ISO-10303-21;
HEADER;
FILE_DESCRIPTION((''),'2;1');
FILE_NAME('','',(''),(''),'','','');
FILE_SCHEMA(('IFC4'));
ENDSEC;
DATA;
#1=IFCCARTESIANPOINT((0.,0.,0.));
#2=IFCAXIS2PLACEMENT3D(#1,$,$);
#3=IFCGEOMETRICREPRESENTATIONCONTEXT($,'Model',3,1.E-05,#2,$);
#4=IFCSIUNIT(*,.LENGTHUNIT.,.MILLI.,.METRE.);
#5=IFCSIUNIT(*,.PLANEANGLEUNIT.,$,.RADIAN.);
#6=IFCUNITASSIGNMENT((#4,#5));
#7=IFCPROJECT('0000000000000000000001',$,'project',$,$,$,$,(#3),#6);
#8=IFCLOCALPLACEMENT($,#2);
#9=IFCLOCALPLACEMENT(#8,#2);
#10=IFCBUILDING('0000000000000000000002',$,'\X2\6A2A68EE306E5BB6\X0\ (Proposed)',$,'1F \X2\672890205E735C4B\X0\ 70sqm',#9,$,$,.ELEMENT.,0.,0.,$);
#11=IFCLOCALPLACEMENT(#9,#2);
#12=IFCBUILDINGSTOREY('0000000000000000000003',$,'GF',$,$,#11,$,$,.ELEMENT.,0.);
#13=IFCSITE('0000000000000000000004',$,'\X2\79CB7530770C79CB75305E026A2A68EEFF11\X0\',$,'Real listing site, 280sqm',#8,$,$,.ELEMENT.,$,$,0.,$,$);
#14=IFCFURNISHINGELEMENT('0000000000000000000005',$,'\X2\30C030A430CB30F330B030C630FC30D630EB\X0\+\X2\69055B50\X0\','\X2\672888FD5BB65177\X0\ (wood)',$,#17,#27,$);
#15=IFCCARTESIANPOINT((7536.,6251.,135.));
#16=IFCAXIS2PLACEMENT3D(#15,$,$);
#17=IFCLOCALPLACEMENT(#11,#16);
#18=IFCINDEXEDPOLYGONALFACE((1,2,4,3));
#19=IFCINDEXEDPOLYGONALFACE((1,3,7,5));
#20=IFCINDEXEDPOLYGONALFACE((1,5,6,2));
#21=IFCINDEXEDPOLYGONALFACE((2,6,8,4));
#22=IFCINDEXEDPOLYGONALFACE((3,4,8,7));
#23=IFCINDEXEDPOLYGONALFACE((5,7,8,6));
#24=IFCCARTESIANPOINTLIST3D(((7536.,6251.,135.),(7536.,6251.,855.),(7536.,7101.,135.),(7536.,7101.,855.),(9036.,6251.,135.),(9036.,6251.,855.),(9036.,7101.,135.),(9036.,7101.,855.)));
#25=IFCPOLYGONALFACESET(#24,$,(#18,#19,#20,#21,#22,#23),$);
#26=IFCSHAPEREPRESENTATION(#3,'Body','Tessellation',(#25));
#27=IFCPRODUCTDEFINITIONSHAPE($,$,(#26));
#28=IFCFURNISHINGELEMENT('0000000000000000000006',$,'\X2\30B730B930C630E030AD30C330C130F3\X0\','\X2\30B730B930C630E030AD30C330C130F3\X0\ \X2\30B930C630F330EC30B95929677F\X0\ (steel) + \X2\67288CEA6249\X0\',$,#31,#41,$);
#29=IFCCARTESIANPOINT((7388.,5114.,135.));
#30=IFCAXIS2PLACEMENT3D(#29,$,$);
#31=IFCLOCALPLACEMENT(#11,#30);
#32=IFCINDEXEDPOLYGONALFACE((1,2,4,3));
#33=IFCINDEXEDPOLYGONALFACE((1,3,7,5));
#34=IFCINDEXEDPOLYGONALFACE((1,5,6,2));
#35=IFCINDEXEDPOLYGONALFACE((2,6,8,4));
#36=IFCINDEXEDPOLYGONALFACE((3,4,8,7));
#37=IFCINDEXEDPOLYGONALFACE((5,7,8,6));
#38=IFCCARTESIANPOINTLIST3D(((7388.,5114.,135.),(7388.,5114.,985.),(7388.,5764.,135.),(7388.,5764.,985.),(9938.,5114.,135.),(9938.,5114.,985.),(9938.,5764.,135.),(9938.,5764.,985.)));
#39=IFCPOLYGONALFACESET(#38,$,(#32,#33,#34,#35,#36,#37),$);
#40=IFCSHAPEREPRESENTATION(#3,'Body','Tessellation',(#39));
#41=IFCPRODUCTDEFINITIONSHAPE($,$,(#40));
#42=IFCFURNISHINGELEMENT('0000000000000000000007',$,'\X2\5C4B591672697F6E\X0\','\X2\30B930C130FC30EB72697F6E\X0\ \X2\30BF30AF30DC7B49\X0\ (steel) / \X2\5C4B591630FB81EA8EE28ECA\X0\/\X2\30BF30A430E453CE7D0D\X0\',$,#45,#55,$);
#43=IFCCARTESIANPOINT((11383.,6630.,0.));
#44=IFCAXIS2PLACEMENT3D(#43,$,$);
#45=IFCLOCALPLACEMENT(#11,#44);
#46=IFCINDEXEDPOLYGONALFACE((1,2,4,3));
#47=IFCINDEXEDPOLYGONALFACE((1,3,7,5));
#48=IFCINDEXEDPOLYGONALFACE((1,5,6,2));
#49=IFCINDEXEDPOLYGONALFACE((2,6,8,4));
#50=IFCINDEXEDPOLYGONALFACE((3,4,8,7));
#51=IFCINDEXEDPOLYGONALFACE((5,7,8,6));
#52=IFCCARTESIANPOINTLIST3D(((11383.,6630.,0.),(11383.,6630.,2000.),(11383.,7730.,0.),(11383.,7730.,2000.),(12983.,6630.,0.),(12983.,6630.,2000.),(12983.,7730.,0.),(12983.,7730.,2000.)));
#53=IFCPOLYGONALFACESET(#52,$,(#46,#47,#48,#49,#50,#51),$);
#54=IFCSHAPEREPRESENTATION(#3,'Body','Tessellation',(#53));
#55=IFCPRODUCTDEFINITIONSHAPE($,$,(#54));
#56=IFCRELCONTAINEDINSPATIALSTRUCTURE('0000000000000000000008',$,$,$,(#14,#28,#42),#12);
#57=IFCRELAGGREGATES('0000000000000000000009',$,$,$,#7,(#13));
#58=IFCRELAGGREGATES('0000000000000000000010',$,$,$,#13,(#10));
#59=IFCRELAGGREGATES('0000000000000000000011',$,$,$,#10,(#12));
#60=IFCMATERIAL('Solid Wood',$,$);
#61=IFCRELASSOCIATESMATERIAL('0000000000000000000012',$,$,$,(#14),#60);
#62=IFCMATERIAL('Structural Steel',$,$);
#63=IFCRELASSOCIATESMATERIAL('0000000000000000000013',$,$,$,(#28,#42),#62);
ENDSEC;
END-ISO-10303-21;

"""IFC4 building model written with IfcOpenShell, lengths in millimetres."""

from ifc_helpers import new_model, si_unit, frame, frame_2d, origin, place, context, project, spatial, rectangle, extrude, material, element, save


model = new_model("IFC4")

# Units and contexts
model_context = context("Model", 3, precision=1e-05, world=origin())
ifc_project = project(units=[si_unit("LENGTHUNIT", "METRE", prefix="MILLI"), si_unit("PLANEANGLEUNIT", "RADIAN")], contexts=[model_context])

# Site, building, storey
site_placement = place(None, origin())
site = spatial("IfcSite", under=ifc_project, at=site_placement, Name="秋田県秋田市横森１", ObjectType="Real listing site, 280sqm", CompositionType="ELEMENT", RefElevation=0.0)
building_placement = place(site_placement, origin())
building = spatial("IfcBuilding", under=site, at=building_placement, Name="横森の家 (Proposed)", ObjectType="1F 木造平屋 70sqm", CompositionType="ELEMENT", ElevationOfRefHeight=0.0, ElevationOfTerrain=0.0)
storey_placement = place(building_placement, origin())
storey = spatial("IfcBuildingStorey", under=building, at=storey_placement, Name="GF", CompositionType="ELEMENT", Elevation=0.0)

# Shared definitions
ifc_material_1 = material(Name="Solid Wood")

# Shared definitions
ifc_material_2 = material(Name="Structural Steel")

# Furnishing elements
furnishing_1_placement = place(storey_placement, frame((7536.0, 6251.0, 135.0)))
element("IfcFurnishingElement", 1, at=furnishing_1_placement, inside=storey, material=ifc_material_1, Name="ダイニングテーブル+椅子", Description="木製家具 (wood)", context=model_context, shape_type="SweptSolid", body=[
    extrude(rectangle(XDim=1500.0, YDim=850.0, at=frame_2d((750.0, 425.0))), frame((7536.0, 6251.0, 135.0)), (0.0, 0.0, 1.0), 720.0),
])
furnishing_2_placement = place(storey_placement, frame((7388.0, 5114.0, 135.0)))
element("IfcFurnishingElement", 2, at=furnishing_2_placement, inside=storey, material=ifc_material_2, Name="システムキッチン", Description="システムキッチン ステンレス天板 (steel) + 木質扉", context=model_context, shape_type="SweptSolid", body=[
    extrude(rectangle(XDim=2550.0, YDim=650.0, at=frame_2d((1275.0, 325.0))), frame((7388.0, 5114.0, 135.0)), (0.0, 0.0, 1.0), 850.0),
])
furnishing_3_placement = place(storey_placement, frame((11383.0, 6630.0, 0.0)))
element("IfcFurnishingElement", 3, at=furnishing_3_placement, inside=storey, material=ifc_material_2, Name="屋外物置", Description="スチール物置 タクボ等 (steel) / 屋外・自転車/タイヤ収納", context=model_context, shape_type="SweptSolid", body=[
    extrude(rectangle(XDim=1600.0, YDim=1100.0, at=frame_2d((800.0, 550.0))), frame((11383.0, 6630.0, 0.0)), (0.0, 0.0, 1.0), 2000.0),
])

save(model, "model.ifc")
